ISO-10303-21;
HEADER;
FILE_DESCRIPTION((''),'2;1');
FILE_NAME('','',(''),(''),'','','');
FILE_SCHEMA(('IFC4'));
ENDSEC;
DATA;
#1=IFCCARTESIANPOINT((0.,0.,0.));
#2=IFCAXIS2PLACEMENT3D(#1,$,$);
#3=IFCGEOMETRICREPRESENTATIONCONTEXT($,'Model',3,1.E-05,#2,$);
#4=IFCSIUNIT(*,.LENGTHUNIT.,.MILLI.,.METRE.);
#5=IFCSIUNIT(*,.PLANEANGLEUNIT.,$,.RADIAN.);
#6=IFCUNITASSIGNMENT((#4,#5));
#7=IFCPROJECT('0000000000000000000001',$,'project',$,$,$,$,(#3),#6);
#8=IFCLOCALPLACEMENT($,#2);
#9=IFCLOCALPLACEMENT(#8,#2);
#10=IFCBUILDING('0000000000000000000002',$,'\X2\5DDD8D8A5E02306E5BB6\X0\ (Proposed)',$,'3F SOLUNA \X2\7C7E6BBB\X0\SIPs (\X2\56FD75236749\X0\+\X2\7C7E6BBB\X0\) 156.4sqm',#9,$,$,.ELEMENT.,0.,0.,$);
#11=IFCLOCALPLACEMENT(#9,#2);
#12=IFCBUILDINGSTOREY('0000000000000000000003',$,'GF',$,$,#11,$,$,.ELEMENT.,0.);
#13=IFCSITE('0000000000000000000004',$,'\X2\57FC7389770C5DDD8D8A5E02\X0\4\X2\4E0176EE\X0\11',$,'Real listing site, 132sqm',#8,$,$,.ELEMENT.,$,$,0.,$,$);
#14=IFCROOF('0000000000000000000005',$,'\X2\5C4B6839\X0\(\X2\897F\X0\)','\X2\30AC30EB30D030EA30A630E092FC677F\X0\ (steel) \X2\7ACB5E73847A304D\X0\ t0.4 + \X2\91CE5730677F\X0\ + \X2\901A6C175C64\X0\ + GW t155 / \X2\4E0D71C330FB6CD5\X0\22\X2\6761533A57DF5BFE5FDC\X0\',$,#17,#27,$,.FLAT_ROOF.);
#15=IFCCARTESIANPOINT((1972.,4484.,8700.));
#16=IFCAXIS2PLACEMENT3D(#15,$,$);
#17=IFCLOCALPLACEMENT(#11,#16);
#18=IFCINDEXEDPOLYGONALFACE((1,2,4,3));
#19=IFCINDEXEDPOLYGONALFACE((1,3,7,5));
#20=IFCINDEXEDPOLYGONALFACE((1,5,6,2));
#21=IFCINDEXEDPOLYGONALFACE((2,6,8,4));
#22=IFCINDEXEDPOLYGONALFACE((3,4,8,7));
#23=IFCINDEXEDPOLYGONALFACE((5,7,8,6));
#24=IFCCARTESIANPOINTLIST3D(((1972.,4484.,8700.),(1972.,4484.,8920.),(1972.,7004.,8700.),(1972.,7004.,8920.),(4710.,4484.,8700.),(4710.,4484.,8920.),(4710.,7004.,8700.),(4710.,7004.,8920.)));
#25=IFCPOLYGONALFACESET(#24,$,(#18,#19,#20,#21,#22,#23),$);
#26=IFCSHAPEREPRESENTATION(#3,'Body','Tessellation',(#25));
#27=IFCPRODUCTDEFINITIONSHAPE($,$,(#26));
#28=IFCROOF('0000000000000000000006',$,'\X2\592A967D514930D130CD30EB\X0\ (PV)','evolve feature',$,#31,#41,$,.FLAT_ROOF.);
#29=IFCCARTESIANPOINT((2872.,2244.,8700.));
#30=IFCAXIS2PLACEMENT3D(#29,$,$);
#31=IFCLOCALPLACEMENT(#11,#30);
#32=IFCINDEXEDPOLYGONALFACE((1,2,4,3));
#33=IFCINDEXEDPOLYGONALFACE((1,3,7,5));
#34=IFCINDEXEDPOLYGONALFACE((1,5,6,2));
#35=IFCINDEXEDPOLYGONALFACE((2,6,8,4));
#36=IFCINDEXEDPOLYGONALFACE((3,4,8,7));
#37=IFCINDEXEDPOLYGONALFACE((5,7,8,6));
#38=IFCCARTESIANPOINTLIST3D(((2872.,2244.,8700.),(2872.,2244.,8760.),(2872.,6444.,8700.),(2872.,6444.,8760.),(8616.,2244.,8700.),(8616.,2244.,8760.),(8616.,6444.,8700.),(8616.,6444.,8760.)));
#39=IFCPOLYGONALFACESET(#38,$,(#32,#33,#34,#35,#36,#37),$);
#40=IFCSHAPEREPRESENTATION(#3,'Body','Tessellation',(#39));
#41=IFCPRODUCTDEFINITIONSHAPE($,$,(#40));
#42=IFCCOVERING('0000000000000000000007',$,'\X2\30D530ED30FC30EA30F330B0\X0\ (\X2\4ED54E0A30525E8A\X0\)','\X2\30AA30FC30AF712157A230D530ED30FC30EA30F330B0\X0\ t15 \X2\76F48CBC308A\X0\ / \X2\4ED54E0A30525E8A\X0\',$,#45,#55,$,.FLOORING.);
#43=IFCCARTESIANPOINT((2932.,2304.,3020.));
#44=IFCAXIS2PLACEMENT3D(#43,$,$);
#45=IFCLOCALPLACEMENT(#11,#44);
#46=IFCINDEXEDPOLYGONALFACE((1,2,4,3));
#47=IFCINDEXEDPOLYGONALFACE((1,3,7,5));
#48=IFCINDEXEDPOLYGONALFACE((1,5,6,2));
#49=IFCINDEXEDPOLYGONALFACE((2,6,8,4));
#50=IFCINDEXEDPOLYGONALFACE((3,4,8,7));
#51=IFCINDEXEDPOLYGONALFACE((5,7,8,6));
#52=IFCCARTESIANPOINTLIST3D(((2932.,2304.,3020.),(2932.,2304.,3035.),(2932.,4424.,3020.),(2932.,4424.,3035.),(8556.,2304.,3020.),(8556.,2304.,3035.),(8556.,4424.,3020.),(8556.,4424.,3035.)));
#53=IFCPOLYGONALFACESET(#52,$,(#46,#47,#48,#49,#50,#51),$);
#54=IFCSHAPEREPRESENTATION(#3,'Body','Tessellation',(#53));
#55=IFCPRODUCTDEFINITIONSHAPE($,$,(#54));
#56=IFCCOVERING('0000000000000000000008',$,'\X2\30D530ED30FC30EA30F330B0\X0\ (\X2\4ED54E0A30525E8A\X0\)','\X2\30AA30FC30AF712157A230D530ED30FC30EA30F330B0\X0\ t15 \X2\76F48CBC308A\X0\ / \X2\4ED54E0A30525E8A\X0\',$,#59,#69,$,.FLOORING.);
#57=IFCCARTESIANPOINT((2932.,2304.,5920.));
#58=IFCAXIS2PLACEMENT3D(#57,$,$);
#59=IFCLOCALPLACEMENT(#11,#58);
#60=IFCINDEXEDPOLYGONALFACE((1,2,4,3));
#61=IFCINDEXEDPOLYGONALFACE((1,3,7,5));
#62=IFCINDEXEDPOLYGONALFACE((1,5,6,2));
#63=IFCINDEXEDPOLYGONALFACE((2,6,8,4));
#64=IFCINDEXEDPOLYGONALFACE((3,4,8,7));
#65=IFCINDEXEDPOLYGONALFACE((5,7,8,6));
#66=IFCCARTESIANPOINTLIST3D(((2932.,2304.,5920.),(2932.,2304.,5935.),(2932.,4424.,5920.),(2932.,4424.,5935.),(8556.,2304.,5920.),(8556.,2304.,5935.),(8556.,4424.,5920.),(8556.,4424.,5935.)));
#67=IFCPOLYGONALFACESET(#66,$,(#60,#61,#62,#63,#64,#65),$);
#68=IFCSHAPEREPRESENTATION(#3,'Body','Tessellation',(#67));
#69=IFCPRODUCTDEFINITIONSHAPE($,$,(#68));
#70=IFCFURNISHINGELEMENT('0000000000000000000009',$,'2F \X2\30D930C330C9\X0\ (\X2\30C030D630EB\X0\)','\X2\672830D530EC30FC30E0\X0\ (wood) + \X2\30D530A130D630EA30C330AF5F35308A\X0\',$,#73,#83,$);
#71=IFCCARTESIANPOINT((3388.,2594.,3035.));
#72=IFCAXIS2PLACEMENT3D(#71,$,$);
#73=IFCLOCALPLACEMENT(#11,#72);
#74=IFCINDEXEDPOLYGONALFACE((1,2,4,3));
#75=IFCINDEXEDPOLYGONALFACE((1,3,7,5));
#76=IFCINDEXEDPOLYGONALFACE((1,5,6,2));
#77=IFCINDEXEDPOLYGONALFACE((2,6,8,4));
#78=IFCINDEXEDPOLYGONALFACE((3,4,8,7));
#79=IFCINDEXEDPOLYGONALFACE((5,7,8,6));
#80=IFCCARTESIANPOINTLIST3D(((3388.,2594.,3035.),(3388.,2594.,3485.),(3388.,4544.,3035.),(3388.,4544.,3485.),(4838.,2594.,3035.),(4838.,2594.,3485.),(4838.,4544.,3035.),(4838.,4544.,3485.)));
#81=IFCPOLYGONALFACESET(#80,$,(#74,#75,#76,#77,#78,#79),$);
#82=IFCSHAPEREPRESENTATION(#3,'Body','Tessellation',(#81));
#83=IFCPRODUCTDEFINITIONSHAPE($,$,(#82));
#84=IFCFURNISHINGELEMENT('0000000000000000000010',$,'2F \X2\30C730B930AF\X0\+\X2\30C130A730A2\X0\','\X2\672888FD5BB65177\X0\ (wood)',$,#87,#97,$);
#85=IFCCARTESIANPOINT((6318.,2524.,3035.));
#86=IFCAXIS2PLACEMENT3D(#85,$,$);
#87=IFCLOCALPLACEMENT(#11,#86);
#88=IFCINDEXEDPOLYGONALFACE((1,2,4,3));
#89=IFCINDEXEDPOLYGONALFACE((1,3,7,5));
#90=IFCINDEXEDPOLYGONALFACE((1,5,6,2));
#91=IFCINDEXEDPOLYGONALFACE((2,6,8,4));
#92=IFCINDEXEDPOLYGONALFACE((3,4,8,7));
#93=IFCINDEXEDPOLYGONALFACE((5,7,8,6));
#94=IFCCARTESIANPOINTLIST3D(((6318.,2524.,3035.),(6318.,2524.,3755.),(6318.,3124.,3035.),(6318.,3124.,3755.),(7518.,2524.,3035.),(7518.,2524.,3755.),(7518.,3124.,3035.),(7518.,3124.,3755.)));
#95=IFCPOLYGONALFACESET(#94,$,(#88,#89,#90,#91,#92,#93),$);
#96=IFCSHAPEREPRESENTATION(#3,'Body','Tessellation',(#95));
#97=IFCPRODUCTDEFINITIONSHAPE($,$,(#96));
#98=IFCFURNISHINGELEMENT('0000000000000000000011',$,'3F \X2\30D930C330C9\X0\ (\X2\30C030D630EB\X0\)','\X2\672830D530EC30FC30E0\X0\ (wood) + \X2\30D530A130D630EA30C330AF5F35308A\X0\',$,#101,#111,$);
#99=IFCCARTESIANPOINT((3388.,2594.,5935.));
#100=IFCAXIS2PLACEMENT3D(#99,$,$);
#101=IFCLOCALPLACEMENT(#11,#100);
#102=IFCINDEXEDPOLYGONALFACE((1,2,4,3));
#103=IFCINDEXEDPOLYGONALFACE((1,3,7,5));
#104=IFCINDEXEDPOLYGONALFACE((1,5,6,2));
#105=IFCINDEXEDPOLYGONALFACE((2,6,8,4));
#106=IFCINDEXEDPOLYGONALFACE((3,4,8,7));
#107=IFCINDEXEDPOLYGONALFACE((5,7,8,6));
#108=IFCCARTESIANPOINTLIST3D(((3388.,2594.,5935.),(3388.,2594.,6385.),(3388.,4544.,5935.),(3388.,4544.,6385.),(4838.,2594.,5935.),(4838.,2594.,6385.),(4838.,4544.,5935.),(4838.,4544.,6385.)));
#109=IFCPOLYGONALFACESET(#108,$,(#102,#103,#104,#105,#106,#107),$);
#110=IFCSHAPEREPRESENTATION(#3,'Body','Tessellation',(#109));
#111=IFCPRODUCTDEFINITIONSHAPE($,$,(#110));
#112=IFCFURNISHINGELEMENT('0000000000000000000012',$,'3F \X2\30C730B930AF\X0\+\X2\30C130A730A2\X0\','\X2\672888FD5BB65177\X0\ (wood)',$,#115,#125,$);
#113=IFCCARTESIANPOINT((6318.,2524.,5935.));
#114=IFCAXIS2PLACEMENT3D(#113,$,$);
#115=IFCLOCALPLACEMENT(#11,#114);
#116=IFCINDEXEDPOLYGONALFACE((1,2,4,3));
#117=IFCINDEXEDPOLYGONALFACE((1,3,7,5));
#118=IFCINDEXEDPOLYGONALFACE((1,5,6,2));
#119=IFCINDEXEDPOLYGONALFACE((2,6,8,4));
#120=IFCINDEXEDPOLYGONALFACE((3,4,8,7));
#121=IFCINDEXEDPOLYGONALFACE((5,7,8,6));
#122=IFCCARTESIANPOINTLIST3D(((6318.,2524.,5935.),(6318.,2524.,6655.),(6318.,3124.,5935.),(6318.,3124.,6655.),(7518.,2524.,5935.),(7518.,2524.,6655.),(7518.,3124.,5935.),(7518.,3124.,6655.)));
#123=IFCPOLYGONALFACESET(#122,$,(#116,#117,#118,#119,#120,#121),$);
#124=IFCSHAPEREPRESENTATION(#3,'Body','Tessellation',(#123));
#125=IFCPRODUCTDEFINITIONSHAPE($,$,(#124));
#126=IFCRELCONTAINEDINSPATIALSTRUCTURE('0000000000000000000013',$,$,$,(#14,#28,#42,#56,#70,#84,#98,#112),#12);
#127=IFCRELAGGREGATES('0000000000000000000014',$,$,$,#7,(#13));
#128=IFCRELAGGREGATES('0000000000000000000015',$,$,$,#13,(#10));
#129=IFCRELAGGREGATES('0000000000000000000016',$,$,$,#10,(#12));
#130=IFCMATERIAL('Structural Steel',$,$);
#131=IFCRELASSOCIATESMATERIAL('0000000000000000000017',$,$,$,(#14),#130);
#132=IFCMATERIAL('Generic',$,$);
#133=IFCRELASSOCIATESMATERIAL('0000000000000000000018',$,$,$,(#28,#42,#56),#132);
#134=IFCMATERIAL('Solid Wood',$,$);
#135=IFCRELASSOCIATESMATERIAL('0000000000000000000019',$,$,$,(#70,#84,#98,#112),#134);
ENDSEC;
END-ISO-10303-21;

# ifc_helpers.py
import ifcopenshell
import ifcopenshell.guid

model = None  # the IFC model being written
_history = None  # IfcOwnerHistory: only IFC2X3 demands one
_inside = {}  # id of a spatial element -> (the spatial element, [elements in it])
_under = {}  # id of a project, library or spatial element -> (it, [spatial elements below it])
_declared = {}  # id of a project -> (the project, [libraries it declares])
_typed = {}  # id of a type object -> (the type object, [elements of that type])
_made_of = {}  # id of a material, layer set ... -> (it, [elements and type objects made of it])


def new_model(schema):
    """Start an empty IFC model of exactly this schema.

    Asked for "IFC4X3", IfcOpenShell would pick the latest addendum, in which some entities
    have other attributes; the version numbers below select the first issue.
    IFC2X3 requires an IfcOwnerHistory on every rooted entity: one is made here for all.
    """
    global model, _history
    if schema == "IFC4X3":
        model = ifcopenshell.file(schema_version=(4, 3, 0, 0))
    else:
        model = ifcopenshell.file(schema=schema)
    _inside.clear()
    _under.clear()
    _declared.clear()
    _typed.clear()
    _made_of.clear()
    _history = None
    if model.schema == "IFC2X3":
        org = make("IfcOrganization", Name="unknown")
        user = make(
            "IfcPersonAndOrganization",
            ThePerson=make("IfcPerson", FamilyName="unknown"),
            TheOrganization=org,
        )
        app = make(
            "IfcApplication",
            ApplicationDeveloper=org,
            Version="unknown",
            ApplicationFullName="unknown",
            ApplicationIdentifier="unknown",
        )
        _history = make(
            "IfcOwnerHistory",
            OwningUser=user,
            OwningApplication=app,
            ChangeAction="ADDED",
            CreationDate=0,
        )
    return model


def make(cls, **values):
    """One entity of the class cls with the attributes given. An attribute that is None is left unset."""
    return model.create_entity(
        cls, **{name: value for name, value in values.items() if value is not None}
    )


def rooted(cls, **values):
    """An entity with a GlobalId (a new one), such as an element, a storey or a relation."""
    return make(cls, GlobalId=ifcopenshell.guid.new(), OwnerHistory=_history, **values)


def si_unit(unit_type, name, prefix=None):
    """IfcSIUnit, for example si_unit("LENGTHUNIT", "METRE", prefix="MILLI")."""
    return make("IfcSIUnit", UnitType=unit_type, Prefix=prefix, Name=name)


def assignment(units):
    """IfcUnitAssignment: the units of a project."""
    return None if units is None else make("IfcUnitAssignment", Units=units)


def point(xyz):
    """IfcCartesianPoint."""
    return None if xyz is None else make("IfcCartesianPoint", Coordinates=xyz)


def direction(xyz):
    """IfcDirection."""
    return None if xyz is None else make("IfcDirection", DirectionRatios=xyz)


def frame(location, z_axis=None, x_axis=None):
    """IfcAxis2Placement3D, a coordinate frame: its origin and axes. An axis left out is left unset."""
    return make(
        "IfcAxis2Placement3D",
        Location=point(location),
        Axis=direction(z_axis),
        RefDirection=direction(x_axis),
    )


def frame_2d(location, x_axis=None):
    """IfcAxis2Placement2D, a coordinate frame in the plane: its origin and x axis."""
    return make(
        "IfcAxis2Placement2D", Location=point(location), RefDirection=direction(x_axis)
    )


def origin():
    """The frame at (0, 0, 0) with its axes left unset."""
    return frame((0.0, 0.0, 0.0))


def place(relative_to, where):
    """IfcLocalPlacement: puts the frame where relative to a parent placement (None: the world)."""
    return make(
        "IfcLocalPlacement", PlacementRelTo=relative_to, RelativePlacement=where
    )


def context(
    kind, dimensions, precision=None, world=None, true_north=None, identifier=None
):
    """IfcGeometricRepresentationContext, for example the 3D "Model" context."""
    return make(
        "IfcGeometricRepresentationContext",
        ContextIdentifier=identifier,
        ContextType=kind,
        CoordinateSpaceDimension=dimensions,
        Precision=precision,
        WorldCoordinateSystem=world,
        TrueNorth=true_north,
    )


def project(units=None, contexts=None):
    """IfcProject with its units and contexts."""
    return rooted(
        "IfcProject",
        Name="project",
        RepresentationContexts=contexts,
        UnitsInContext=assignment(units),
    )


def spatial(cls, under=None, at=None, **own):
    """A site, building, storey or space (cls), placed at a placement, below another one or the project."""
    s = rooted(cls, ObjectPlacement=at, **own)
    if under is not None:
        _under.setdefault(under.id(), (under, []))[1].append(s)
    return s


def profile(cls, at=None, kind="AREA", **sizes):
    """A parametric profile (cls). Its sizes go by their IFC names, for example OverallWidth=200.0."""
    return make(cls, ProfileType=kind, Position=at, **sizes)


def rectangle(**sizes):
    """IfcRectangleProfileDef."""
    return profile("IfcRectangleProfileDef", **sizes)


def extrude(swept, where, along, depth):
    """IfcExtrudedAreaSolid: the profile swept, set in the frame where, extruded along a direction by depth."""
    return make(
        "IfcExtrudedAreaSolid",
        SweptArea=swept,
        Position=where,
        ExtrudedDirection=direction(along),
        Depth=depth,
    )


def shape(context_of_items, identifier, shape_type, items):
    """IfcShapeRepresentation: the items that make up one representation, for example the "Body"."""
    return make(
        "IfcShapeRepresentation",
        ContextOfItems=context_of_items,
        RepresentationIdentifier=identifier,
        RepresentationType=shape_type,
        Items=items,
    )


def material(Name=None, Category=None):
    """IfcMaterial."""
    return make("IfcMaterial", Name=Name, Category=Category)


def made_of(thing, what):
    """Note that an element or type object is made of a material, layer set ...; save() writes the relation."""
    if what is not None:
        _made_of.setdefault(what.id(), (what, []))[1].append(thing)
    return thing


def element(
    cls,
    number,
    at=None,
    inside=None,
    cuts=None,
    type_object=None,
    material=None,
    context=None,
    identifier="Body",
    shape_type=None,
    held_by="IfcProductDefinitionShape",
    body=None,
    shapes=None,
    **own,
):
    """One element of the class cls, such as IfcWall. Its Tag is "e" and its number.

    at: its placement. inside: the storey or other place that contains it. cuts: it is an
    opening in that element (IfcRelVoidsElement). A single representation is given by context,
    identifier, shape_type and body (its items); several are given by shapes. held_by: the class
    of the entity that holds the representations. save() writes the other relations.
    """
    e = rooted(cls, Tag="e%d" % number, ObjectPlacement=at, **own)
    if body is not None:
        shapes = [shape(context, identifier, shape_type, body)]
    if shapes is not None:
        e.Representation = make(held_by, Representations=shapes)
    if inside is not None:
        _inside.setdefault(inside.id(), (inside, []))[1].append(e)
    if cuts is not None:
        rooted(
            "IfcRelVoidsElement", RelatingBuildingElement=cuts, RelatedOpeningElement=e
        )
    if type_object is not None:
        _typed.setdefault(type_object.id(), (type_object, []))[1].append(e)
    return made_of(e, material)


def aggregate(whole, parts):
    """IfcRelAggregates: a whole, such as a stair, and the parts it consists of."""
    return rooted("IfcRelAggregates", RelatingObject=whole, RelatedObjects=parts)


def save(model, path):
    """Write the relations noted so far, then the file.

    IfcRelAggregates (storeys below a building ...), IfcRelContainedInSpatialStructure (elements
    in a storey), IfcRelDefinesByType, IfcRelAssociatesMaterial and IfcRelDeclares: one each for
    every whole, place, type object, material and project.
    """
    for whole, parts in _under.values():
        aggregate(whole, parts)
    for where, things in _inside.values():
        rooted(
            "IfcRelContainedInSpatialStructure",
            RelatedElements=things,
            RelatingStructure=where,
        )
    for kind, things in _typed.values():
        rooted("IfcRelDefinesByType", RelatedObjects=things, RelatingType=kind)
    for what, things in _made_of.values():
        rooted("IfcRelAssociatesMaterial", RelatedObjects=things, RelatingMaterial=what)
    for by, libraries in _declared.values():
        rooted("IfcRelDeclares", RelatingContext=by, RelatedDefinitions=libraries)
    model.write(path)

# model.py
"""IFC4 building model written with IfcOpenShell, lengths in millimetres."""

from ifc_helpers import new_model, si_unit, frame, frame_2d, origin, place, context, project, spatial, rectangle, extrude, material, element, save


model = new_model("IFC4")

# Units and contexts
model_context = context("Model", 3, precision=1e-05, world=origin())
ifc_project = project(units=[si_unit("LENGTHUNIT", "METRE", prefix="MILLI"), si_unit("PLANEANGLEUNIT", "RADIAN")], contexts=[model_context])

# Site, building, storey
site_placement = place(None, origin())
site = spatial("IfcSite", under=ifc_project, at=site_placement, Name="埼玉県川越市4丁目11", ObjectType="Real listing site, 132sqm", CompositionType="ELEMENT", RefElevation=0.0)
building_placement = place(site_placement, origin())
building = spatial("IfcBuilding", under=site, at=building_placement, Name="川越市の家 (Proposed)", ObjectType="3F SOLUNA 籾殻SIPs (国産杉+籾殻) 156.4sqm", CompositionType="ELEMENT", ElevationOfRefHeight=0.0, ElevationOfTerrain=0.0)
storey_placement = place(building_placement, origin())
storey = spatial("IfcBuildingStorey", under=building, at=storey_placement, Name="GF", CompositionType="ELEMENT", Elevation=0.0)

# Shared definitions
ifc_material_1 = material(Name="Solid Wood")

# Roofs
ifc_material_2 = material(Name="Structural Steel")
roof_1_placement = place(storey_placement, frame((1972.0, 4484.0, 8700.0)))
element("IfcRoof", 1, at=roof_1_placement, inside=storey, material=ifc_material_2, Name="屋根(西)", Description="ガルバリウム鋼板 (steel) 立平葺き t0.4 + 野地板 + 通気層 + GW t155 / 不燃・法22条区域対応", PredefinedType="FLAT_ROOF", context=model_context, shape_type="SweptSolid", body=[
    extrude(rectangle(XDim=2738.0, YDim=2520.0, at=frame_2d((1369.0, 1260.0))), frame((1972.0, 4484.0, 8700.0)), (0.0, 0.0, 1.0), 220.0),
])
ifc_material_3 = material(Name="Generic")
roof_2_placement = place(storey_placement, frame((2872.0, 2244.0, 8700.0)))
element("IfcRoof", 2, at=roof_2_placement, inside=storey, material=ifc_material_3, Name="太陽光パネル (PV)", Description="evolve feature", PredefinedType="FLAT_ROOF", context=model_context, shape_type="SweptSolid", body=[
    extrude(rectangle(XDim=5744.0, YDim=4200.0, at=frame_2d((2872.0, 2100.0))), frame((2872.0, 2244.0, 8700.0)), (0.0, 0.0, 1.0), 60.0),
])

# Coverings
covering_1_placement = place(storey_placement, frame((2932.0, 2304.0, 3020.0)))
element("IfcCovering", 3, at=covering_1_placement, inside=storey, material=ifc_material_3, Name="フローリング (仕上げ床)", Description="オーク無垢フローリング t15 直貼り / 仕上げ床", PredefinedType="FLOORING", context=model_context, shape_type="SweptSolid", body=[
    extrude(rectangle(XDim=5624.0, YDim=2120.0, at=frame_2d((2812.0, 1060.0))), frame((2932.0, 2304.0, 3020.0)), (0.0, 0.0, 1.0), 15.0),
])
covering_2_placement = place(storey_placement, frame((2932.0, 2304.0, 5920.0)))
element("IfcCovering", 4, at=covering_2_placement, inside=storey, material=ifc_material_3, Name="フローリング (仕上げ床)", Description="オーク無垢フローリング t15 直貼り / 仕上げ床", PredefinedType="FLOORING", context=model_context, shape_type="SweptSolid", body=[
    extrude(rectangle(XDim=5624.0, YDim=2120.0, at=frame_2d((2812.0, 1060.0))), frame((2932.0, 2304.0, 5920.0)), (0.0, 0.0, 1.0), 15.0),
])

# Furnishing elements
furnishing_1_placement = place(storey_placement, frame((3388.0, 2594.0, 3035.0)))
element("IfcFurnishingElement", 5, at=furnishing_1_placement, inside=storey, material=ifc_material_1, Name="2F ベッド (ダブル)", Description="木フレーム (wood) + ファブリック張り", context=model_context, shape_type="SweptSolid", body=[
    extrude(rectangle(XDim=1450.0, YDim=1950.0, at=frame_2d((725.0, 975.0))), frame((3388.0, 2594.0, 3035.0)), (0.0, 0.0, 1.0), 450.0),
])
furnishing_2_placement = place(storey_placement, frame((6318.0, 2524.0, 3035.0)))
element("IfcFurnishingElement", 6, at=furnishing_2_placement, inside=storey, material=ifc_material_1, Name="2F デスク+チェア", Description="木製家具 (wood)", context=model_context, shape_type="SweptSolid", body=[
    extrude(rectangle(XDim=1200.0, YDim=600.0, at=frame_2d((600.0, 300.0))), frame((6318.0, 2524.0, 3035.0)), (0.0, 0.0, 1.0), 720.0),
])
furnishing_3_placement = place(storey_placement, frame((3388.0, 2594.0, 5935.0)))
element("IfcFurnishingElement", 7, at=furnishing_3_placement, inside=storey, material=ifc_material_1, Name="3F ベッド (ダブル)", Description="木フレーム (wood) + ファブリック張り", context=model_context, shape_type="SweptSolid", body=[
    extrude(rectangle(XDim=1450.0, YDim=1950.0, at=frame_2d((725.0, 975.0))), frame((3388.0, 2594.0, 5935.0)), (0.0, 0.0, 1.0), 450.0),
])
furnishing_4_placement = place(storey_placement, frame((6318.0, 2524.0, 5935.0)))
element("IfcFurnishingElement", 8, at=furnishing_4_placement, inside=storey, material=ifc_material_1, Name="3F デスク+チェア", Description="木製家具 (wood)", context=model_context, shape_type="SweptSolid", body=[
    extrude(rectangle(XDim=1200.0, YDim=600.0, at=frame_2d((600.0, 300.0))), frame((6318.0, 2524.0, 5935.0)), (0.0, 0.0, 1.0), 720.0),
])

save(model, "model.ifc")
